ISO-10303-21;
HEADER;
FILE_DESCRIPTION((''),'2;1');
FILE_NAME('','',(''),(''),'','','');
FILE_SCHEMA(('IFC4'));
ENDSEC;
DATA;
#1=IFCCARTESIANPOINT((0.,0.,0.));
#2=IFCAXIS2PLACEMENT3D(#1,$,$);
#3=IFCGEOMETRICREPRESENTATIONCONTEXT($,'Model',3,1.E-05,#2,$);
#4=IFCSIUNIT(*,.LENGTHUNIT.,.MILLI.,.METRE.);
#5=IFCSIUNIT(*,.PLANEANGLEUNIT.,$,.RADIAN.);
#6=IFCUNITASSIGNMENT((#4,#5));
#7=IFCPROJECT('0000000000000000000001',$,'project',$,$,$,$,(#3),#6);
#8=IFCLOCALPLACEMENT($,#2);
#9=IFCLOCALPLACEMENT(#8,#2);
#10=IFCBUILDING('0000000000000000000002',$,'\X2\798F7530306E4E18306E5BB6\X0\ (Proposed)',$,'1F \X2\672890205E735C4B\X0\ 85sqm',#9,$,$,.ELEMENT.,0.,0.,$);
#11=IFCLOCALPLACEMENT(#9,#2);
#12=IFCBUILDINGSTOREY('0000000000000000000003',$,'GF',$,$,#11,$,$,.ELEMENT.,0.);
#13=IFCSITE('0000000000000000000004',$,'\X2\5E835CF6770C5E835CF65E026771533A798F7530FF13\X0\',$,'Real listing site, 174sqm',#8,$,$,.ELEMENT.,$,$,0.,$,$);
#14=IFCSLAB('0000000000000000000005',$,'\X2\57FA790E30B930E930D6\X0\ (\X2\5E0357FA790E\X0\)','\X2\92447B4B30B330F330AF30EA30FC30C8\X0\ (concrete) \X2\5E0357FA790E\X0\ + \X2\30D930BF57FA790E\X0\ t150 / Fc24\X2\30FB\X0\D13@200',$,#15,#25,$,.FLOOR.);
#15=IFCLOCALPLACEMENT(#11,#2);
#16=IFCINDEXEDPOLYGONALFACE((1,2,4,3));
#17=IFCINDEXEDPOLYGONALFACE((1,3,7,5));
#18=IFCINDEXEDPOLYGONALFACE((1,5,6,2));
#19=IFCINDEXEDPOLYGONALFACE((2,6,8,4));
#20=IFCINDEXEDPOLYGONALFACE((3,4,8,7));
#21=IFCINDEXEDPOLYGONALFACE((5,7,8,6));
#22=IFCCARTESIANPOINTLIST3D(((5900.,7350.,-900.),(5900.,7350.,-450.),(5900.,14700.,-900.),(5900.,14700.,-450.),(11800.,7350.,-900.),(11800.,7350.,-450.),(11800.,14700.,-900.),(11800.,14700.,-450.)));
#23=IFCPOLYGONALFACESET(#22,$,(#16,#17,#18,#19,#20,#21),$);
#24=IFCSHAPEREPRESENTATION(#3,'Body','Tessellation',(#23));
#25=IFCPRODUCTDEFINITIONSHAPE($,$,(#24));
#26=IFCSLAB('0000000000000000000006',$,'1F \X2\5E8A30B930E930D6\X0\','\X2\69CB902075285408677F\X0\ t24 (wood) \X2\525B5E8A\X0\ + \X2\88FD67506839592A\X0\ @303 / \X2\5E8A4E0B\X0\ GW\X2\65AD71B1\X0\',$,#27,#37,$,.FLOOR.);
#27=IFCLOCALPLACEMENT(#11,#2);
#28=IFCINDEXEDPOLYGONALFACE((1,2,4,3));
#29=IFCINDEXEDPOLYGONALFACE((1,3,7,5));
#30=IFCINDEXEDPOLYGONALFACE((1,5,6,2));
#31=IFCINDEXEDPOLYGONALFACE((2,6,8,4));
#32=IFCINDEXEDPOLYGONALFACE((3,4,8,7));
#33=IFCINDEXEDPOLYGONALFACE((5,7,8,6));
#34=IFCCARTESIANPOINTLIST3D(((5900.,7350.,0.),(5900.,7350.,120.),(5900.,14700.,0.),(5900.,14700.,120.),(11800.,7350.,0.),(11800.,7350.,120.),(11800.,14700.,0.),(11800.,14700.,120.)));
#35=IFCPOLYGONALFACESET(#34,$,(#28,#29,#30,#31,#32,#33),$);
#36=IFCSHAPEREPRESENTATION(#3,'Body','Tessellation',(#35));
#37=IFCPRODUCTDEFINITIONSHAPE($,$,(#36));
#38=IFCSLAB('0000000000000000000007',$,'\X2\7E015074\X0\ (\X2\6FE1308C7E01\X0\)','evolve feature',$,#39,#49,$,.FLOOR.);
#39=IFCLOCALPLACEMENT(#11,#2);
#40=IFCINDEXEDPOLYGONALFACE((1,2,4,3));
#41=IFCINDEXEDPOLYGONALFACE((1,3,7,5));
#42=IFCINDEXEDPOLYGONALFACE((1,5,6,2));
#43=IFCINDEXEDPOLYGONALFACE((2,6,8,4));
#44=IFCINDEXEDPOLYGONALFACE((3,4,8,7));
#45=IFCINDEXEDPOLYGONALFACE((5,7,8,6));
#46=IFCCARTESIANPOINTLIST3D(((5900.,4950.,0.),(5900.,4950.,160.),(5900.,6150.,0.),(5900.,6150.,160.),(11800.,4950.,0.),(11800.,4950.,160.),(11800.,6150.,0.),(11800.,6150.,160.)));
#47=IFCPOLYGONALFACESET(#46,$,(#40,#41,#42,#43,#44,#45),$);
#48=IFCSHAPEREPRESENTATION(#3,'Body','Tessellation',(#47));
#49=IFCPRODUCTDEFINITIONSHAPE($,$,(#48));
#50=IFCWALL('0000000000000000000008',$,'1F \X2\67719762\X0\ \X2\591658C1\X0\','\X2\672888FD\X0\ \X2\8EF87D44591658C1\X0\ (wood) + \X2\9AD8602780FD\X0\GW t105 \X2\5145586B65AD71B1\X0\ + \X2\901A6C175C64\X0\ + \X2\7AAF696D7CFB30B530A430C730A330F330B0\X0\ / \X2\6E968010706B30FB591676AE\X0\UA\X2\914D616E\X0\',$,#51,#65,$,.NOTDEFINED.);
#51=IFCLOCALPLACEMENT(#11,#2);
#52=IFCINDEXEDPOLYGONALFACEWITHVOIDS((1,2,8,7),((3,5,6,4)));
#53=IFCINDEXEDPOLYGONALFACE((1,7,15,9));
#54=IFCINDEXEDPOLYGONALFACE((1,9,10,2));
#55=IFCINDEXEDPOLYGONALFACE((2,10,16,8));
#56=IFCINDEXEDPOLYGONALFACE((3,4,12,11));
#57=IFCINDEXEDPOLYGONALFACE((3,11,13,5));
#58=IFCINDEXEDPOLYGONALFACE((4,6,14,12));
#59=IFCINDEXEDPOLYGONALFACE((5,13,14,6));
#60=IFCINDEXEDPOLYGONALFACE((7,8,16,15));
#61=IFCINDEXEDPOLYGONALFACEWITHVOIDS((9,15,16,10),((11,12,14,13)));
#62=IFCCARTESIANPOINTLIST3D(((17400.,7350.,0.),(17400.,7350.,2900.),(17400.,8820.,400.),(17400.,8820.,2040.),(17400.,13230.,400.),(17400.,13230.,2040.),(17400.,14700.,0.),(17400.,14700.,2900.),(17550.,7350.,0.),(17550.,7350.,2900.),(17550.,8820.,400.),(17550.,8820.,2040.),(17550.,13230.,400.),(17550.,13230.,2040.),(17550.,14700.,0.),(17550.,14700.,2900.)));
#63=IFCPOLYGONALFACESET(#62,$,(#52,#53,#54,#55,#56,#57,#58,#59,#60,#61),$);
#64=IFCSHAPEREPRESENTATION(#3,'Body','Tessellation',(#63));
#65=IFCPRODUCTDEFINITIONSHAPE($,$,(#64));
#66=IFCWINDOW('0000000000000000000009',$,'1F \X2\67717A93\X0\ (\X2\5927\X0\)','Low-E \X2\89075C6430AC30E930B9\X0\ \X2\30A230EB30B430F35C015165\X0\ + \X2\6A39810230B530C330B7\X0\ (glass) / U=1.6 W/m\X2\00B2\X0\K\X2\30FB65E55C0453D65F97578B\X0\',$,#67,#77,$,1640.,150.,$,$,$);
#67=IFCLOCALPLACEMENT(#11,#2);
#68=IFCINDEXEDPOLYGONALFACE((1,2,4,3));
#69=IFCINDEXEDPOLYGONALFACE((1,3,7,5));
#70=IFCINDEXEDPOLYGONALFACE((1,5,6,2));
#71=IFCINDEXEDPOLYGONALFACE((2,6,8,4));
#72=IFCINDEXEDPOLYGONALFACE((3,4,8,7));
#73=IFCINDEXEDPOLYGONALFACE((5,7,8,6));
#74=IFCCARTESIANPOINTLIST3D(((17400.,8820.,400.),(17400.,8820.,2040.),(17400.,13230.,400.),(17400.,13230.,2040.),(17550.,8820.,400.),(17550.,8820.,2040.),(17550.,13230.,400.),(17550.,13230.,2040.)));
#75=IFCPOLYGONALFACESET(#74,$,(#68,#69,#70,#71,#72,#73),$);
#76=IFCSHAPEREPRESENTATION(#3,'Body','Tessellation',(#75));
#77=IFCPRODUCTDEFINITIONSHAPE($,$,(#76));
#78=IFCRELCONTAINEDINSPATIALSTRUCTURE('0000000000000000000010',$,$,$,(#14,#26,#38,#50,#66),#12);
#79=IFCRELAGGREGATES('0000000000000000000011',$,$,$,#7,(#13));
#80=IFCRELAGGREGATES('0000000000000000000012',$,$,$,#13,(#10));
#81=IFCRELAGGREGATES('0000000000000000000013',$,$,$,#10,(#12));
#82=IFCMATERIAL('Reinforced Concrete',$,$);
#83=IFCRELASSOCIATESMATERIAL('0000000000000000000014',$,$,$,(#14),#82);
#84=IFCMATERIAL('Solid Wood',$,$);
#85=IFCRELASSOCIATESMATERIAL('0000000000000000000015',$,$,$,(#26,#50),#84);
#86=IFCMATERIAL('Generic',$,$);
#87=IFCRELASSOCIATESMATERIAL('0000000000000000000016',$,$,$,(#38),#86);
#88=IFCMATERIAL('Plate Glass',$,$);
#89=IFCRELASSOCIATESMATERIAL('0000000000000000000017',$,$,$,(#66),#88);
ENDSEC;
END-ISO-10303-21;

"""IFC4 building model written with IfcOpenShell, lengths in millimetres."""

from ifc_helpers import new_model, si_unit, frame, frame_2d, origin, place, context, project, spatial, rectangle, extrude, material, element, fill, save


model = new_model("IFC4")

# Units and contexts
model_context = context("Model", 3, precision=1e-05, world=origin())
ifc_project = project(units=[si_unit("LENGTHUNIT", "METRE", prefix="MILLI"), si_unit("PLANEANGLEUNIT", "RADIAN")], contexts=[model_context])

# Site, building, storey
site_placement = place(None, origin())
site = spatial("IfcSite", under=ifc_project, at=site_placement, Name="広島県広島市東区福田３", ObjectType="Real listing site, 174sqm", CompositionType="ELEMENT", RefElevation=0.0)
building_placement = place(site_placement, origin())
building = spatial("IfcBuilding", under=site, at=building_placement, Name="福田の丘の家 (Proposed)", ObjectType="1F 木造平屋 85sqm", CompositionType="ELEMENT", ElevationOfRefHeight=0.0, ElevationOfTerrain=0.0)
storey_placement = place(building_placement, origin())
storey = spatial("IfcBuildingStorey", under=building, at=storey_placement, Name="GF", CompositionType="ELEMENT", Elevation=0.0)

# Slabs
ifc_material_1 = material(Name="Reinforced Concrete")
slab_1_placement = place(storey_placement, frame((2950.0, 3675.0, -450.0)))
element("IfcSlab", 1, at=slab_1_placement, inside=storey, material=ifc_material_1, Name="基礎スラブ (布基礎)", Description="鉄筋コンクリート (concrete) 布基礎 + ベタ基礎 t150 / Fc24・D13@200", PredefinedType="FLOOR", context=model_context, shape_type="SweptSolid", body=[
    extrude(rectangle(XDim=5900.0, YDim=7350.0, at=frame_2d((2950.0, 3675.0))), frame((2950.0, 3675.0, -450.0)), (0.0, 0.0, 1.0), 450.0),
])
ifc_material_2 = material(Name="Solid Wood")
slab_2_placement = place(storey_placement, frame((2950.0, 3675.0, 0.0)))
element("IfcSlab", 2, at=slab_2_placement, inside=storey, material=ifc_material_2, Name="1F 床スラブ", Description="構造用合板 t24 (wood) 剛床 + 製材根太 @303 / 床下 GW断熱", PredefinedType="FLOOR", context=model_context, shape_type="SweptSolid", body=[
    extrude(rectangle(XDim=5900.0, YDim=7350.0, at=frame_2d((2950.0, 3675.0))), frame((2950.0, 3675.0, 0.0)), (0.0, 0.0, 1.0), 120.0),
])
ifc_material_3 = material(Name="Generic")
slab_3_placement = place(storey_placement, frame((2950.0, 2475.0, 0.0)))
element("IfcSlab", 3, at=slab_3_placement, inside=storey, material=ifc_material_3, Name="縁側 (濡れ縁)", Description="evolve feature", PredefinedType="FLOOR", context=model_context, shape_type="SweptSolid", body=[
    extrude(rectangle(XDim=5900.0, YDim=1200.0, at=frame_2d((2950.0, 600.0))), frame((2950.0, 2475.0, 0.0)), (0.0, 0.0, 1.0), 160.0),
])

# Shared definitions
ifc_material_4 = material(Name="Plate Glass")

# Wall, opening, window
wall_1_placement = place(storey_placement, frame((8700.0, 3675.0, 0.0)))
wall_1 = element("IfcWall", 4, at=wall_1_placement, inside=storey, material=ifc_material_2, Name="1F 東面 外壁", Description="木製 軸組外壁 (wood) + 高性能GW t105 充填断熱 + 通気層 + 窯業系サイディング / 準耐火・外皮UA配慮", PredefinedType="NOTDEFINED", context=model_context, shape_type="SweptSolid", body=[
    extrude(rectangle(XDim=150.0, YDim=7350.0, at=frame_2d((75.0, 3675.0))), frame((8700.0, 3675.0, 0.0)), (0.0, 0.0, 1.0), 2900.0),
])
opening_1_placement = place(storey_placement, frame((8700.0, 4410.0, 200.0)))
opening_1 = element("IfcOpeningElement", 5, at=opening_1_placement, cuts=wall_1, PredefinedType="NOTDEFINED", context=model_context, shape_type="SweptSolid", body=[
    extrude(rectangle(XDim=150.0, YDim=4410.0, at=frame_2d((75.0, 2205.0))), frame((8700.0, 4410.0, 200.0)), (0.0, 0.0, 1.0), 1640.0),
])
window_1_placement = place(storey_placement, frame((8700.0, 4410.0, 200.0)))
window_1 = element("IfcWindow", 6, at=window_1_placement, inside=storey, material=ifc_material_4, Name="1F 東窓 (大)", Description="Low-E 複層ガラス アルゴン封入 + 樹脂サッシ (glass) / U=1.6 W/m²K・日射取得型", OverallHeight=1640.0, OverallWidth=150.0, context=model_context, shape_type="SweptSolid", body=[
    extrude(rectangle(XDim=150.0, YDim=4410.0, at=frame_2d((75.0, 2205.0))), frame((8700.0, 4410.0, 200.0)), (0.0, 0.0, 1.0), 1640.0),
])
fill(opening_1, window_1)

save(model, "model.ifc")
